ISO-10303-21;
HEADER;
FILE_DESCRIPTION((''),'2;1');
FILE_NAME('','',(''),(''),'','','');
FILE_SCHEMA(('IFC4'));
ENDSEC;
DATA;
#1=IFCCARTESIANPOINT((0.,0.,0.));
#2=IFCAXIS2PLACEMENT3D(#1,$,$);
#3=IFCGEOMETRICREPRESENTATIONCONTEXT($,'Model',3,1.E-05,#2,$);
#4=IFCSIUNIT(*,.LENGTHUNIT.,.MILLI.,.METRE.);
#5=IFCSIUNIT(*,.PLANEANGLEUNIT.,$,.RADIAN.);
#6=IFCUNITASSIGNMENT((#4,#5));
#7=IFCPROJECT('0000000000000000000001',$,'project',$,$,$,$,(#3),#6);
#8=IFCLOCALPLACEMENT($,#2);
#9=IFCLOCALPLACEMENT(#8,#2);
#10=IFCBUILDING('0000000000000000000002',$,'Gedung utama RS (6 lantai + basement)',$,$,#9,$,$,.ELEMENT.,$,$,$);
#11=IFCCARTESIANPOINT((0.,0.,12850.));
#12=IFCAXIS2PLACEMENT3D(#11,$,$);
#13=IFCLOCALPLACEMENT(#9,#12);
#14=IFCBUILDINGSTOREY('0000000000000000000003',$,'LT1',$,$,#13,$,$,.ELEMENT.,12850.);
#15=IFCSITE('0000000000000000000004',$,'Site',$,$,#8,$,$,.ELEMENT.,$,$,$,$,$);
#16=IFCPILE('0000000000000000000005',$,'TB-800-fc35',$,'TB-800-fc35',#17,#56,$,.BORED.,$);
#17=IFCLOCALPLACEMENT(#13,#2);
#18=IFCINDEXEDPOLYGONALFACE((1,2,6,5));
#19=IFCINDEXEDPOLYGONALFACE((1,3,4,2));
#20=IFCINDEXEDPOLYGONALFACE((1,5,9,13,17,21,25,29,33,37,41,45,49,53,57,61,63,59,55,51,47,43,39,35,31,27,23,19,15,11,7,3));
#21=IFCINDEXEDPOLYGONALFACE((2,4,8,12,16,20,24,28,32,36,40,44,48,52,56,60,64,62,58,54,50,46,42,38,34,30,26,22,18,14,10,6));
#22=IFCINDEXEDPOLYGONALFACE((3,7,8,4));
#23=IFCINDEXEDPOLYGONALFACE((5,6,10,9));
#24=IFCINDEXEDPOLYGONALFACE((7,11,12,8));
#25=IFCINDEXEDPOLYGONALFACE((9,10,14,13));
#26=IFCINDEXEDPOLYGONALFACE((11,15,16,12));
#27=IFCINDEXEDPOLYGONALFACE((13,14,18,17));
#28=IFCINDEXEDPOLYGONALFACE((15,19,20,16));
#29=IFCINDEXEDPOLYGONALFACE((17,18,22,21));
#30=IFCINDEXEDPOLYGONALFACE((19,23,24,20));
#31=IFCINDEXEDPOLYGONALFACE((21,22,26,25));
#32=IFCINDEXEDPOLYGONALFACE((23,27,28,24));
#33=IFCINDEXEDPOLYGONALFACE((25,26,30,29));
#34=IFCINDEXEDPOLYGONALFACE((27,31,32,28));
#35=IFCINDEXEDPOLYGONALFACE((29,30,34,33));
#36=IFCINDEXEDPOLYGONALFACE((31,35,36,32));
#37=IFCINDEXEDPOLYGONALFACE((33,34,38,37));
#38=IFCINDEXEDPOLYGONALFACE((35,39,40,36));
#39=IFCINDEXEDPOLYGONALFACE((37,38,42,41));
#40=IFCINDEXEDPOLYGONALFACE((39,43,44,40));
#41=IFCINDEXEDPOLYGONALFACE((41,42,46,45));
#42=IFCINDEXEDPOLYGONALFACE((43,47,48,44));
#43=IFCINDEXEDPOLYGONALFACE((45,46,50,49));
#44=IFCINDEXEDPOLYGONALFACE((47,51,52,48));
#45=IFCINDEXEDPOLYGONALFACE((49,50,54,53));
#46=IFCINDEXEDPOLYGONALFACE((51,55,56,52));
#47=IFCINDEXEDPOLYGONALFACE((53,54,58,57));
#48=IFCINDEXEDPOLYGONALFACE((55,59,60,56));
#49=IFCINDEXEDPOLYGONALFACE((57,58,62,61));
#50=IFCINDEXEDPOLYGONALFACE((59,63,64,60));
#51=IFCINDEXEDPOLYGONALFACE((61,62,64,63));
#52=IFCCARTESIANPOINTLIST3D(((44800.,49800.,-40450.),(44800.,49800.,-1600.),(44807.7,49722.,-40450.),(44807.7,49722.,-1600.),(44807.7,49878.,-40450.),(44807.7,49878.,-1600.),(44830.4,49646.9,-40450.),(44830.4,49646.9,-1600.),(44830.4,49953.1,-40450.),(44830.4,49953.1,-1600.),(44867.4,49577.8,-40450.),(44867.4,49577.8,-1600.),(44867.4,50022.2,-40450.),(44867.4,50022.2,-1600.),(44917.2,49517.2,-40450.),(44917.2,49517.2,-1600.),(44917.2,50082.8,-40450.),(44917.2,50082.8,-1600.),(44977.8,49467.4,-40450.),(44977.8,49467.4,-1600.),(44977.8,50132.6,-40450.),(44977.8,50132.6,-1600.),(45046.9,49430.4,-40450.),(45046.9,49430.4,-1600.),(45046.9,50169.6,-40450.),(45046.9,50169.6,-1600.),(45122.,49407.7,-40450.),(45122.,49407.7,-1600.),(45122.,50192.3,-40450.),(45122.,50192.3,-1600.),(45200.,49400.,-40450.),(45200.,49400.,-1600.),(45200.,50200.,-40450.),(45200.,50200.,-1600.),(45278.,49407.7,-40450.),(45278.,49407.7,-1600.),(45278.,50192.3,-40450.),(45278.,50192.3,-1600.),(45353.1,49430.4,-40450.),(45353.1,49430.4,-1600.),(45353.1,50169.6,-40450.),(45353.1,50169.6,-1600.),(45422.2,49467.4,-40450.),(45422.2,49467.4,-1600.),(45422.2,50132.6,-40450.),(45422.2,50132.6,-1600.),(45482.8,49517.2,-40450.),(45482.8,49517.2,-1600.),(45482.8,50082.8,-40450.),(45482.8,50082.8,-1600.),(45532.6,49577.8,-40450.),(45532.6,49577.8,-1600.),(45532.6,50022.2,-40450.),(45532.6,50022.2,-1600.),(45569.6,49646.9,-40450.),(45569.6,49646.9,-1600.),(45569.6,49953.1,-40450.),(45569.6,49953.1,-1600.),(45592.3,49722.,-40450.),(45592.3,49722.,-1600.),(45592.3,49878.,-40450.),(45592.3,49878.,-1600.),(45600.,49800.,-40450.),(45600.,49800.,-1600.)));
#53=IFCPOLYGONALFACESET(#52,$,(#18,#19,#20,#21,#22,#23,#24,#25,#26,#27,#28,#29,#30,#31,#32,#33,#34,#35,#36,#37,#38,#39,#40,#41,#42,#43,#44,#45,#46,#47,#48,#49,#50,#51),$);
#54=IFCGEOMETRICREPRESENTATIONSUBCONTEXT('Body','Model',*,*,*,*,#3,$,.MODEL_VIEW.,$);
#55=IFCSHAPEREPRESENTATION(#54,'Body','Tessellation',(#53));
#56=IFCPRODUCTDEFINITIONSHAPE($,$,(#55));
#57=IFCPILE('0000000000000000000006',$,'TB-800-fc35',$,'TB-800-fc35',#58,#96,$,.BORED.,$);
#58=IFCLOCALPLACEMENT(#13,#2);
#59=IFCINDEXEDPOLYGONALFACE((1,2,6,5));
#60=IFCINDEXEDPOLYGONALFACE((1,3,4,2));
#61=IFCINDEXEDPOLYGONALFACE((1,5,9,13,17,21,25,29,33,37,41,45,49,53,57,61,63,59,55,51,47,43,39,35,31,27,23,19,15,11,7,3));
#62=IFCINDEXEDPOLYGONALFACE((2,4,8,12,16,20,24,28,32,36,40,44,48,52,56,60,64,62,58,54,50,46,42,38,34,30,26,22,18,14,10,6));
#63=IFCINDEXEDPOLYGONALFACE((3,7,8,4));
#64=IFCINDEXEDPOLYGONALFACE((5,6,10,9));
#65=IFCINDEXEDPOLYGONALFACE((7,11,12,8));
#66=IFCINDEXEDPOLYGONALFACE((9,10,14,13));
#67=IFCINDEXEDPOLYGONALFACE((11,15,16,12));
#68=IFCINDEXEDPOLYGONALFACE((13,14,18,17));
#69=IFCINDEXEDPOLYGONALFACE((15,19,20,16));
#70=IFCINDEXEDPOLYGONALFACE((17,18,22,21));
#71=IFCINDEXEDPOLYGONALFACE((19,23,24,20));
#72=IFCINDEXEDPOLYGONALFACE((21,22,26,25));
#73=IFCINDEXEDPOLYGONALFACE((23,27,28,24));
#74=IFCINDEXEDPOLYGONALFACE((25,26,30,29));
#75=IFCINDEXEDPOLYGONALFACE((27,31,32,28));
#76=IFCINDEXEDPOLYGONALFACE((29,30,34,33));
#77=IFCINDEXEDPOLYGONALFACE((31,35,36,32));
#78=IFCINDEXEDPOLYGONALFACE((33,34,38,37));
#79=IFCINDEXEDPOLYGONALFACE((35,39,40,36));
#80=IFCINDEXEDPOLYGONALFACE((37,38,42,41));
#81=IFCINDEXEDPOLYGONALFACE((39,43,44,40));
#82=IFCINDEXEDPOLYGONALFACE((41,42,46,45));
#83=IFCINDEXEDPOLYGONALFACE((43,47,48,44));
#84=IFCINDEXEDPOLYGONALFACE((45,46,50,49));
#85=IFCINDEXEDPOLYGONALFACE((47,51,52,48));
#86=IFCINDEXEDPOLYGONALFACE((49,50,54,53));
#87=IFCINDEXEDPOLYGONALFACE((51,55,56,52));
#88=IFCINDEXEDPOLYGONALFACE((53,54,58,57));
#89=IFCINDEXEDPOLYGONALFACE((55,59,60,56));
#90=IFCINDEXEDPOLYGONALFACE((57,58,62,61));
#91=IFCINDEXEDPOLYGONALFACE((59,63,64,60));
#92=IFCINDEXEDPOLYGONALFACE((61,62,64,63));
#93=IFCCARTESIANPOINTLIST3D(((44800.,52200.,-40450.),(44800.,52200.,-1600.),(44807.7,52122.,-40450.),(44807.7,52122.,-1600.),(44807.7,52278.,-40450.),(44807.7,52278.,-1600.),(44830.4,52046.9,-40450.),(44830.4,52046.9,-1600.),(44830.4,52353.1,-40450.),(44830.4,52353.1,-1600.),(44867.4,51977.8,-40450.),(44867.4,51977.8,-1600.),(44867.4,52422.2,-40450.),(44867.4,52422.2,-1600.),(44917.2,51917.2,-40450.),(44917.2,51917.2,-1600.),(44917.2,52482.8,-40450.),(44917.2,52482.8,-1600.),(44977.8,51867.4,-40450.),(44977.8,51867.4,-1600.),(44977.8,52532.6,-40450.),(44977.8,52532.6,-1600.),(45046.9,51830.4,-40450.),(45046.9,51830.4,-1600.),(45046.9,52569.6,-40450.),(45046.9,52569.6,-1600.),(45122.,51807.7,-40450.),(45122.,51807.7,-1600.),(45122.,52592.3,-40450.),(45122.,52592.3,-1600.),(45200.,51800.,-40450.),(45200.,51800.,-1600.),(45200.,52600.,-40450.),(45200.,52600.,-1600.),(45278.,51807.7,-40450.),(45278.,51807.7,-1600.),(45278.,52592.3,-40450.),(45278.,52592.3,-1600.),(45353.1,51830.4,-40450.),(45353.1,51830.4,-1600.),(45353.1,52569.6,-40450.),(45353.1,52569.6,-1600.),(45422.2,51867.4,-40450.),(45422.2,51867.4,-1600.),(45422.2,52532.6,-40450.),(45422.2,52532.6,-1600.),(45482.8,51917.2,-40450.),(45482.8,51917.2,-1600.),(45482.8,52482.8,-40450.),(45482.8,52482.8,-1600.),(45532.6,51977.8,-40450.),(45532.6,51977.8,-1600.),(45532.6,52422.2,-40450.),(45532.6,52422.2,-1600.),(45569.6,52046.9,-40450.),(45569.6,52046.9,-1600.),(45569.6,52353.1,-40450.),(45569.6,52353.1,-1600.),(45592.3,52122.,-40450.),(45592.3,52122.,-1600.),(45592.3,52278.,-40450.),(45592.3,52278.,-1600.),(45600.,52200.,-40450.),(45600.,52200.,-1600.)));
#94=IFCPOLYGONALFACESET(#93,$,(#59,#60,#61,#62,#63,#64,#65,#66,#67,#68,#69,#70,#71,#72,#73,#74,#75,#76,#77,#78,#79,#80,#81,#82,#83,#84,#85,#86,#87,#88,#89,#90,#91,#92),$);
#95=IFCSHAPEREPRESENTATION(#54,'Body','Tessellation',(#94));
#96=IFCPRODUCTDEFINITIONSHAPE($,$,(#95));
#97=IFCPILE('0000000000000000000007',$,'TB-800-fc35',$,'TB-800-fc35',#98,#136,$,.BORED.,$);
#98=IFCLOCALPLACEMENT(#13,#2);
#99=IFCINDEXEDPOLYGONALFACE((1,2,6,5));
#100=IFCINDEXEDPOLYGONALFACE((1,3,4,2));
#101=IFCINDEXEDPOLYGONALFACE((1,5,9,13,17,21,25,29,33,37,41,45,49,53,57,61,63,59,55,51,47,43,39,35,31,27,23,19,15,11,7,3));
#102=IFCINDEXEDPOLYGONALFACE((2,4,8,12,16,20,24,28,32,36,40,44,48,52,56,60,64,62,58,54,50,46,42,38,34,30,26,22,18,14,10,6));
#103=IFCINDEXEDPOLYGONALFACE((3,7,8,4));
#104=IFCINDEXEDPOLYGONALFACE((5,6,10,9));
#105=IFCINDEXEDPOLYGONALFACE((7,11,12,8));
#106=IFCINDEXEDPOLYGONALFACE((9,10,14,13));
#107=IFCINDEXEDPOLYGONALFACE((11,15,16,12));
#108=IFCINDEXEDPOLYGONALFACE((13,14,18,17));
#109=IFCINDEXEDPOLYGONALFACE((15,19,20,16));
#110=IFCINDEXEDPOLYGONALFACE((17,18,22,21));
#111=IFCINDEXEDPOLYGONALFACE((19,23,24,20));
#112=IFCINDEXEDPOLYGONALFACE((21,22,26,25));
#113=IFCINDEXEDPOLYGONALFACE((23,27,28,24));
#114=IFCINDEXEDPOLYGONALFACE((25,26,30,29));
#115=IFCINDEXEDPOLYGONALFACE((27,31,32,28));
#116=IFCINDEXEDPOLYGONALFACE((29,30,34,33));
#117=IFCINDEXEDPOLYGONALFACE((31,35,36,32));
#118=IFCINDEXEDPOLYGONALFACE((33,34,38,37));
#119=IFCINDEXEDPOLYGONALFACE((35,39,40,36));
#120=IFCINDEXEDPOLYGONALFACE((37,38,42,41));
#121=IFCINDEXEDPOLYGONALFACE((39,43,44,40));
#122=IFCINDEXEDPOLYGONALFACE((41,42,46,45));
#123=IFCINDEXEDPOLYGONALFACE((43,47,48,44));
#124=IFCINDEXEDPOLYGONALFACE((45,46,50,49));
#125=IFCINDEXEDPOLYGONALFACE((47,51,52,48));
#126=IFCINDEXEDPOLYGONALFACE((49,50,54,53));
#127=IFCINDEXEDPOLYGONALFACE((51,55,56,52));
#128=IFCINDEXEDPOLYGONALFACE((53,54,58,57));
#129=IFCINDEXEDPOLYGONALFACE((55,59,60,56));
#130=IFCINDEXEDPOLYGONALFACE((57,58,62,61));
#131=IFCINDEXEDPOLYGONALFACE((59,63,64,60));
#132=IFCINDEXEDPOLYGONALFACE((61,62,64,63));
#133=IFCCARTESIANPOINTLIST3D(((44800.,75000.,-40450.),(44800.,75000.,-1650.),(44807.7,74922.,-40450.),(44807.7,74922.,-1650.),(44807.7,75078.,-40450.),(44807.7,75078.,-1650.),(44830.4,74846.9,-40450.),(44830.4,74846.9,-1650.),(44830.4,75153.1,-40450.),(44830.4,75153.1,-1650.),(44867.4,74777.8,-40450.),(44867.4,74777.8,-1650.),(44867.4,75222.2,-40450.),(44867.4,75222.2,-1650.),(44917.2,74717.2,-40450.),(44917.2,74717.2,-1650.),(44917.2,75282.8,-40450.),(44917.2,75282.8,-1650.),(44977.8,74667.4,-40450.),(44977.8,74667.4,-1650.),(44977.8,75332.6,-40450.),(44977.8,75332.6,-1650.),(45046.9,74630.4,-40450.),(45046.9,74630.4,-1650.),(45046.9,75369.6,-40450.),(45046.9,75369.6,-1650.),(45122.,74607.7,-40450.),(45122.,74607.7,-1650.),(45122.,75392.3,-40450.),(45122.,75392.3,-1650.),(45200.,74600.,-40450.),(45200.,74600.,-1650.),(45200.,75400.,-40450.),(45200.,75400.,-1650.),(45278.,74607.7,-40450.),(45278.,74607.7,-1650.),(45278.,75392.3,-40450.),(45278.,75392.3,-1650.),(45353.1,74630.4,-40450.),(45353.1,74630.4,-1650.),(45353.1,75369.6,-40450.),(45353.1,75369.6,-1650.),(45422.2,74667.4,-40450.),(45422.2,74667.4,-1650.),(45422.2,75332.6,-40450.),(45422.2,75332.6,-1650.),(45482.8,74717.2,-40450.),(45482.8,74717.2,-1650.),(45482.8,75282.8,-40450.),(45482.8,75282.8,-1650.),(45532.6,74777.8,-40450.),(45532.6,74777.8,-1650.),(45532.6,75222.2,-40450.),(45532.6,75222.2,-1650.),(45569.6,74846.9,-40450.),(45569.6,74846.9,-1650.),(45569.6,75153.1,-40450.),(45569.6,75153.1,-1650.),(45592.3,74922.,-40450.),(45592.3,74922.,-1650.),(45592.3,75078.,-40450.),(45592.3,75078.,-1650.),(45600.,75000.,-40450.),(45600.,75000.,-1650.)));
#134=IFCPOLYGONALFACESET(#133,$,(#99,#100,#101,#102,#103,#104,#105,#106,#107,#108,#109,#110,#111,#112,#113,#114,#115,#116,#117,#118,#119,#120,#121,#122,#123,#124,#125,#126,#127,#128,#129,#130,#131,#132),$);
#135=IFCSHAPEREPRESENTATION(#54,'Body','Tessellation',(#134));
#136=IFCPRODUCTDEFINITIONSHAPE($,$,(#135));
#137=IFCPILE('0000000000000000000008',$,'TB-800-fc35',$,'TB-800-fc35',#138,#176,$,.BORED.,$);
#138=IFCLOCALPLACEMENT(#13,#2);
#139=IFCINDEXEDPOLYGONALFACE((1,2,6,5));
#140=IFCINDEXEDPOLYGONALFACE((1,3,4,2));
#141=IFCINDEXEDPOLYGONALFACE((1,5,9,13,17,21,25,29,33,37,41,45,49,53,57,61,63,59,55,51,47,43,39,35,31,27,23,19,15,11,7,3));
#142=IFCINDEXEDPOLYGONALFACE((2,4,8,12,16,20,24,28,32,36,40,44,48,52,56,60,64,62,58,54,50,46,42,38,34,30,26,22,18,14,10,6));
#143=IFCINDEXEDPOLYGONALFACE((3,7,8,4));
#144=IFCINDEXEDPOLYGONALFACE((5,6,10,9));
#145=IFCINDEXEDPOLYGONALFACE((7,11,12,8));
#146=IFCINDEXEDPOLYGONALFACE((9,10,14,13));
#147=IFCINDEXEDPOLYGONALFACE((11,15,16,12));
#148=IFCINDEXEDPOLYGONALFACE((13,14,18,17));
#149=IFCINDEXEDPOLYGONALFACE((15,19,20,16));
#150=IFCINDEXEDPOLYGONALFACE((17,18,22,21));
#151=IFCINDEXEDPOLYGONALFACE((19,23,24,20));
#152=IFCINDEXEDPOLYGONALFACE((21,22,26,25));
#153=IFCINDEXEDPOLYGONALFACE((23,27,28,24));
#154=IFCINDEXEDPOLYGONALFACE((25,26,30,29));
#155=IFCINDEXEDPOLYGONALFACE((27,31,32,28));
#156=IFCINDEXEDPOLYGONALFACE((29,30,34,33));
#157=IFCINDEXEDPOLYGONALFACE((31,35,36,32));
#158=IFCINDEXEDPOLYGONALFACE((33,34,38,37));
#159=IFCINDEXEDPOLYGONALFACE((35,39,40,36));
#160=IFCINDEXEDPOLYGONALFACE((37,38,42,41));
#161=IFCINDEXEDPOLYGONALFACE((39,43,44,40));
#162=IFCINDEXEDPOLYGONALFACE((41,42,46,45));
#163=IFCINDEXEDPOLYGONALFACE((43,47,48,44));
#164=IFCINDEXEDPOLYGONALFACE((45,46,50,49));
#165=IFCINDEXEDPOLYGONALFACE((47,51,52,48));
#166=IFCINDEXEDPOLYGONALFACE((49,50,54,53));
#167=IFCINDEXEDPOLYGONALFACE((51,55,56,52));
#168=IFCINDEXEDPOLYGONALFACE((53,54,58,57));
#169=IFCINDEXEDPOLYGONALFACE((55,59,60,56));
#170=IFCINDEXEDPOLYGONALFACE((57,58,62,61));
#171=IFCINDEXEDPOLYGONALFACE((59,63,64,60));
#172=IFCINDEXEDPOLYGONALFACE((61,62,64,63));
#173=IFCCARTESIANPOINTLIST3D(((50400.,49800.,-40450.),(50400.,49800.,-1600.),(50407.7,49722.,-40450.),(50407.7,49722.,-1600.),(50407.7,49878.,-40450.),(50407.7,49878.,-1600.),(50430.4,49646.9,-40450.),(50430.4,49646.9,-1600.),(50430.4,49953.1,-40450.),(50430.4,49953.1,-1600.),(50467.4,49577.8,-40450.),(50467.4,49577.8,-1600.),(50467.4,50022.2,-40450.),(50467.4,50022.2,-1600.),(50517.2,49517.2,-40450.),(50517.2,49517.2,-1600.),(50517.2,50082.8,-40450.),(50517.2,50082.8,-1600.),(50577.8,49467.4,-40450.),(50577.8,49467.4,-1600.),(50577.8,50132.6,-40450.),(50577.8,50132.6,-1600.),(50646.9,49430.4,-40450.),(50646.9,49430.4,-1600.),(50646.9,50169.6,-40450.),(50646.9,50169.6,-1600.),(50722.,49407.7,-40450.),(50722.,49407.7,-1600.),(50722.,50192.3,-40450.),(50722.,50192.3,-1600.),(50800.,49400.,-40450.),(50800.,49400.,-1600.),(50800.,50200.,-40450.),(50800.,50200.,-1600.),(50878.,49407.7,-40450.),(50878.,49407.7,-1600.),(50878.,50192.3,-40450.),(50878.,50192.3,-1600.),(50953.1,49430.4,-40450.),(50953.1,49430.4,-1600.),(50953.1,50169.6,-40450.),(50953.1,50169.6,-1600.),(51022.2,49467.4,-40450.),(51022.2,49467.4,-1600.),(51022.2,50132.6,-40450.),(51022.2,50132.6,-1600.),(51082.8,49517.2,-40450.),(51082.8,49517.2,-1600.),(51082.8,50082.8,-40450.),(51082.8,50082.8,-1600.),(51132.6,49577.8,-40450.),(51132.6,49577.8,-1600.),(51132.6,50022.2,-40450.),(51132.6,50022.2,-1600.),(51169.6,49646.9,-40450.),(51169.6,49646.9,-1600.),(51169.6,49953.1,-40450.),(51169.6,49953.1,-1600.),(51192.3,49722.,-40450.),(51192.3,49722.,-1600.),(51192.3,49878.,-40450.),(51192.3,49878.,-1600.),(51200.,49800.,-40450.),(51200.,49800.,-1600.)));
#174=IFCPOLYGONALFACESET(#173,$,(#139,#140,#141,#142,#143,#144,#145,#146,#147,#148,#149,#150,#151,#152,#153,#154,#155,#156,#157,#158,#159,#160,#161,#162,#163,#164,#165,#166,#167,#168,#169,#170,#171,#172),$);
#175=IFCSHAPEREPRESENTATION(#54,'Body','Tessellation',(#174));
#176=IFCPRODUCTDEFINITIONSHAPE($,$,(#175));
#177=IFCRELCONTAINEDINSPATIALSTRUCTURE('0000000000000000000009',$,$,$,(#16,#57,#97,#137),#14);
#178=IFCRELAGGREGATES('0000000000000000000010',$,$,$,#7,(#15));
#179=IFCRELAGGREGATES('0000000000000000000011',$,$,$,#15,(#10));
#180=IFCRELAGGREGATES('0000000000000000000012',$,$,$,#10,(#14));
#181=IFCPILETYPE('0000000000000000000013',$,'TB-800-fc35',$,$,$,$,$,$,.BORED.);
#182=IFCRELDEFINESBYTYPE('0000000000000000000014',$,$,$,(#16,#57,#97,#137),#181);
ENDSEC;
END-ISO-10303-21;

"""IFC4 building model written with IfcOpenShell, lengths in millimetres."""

from ifc_helpers import new_model, si_unit, frame, origin, origin_2d, place, context, subcontext, project, spatial, circle, extrude, material_profile, profile_set, profile_usage, type_object, element, save


model = new_model("IFC4")

# Units and contexts
model_context = context("Model", 3, precision=1e-05, world=origin())
body_context = subcontext(model_context, "Body", "Model", "MODEL_VIEW")
ifc_project = project(units=[si_unit("LENGTHUNIT", "METRE", prefix="MILLI"), si_unit("PLANEANGLEUNIT", "RADIAN")], contexts=[model_context])

# Site, building, storey
site_placement = place(None, origin())
site = spatial("IfcSite", under=ifc_project, at=site_placement, Name="Site", CompositionType="ELEMENT")
building_placement = place(site_placement, origin())
building = spatial("IfcBuilding", under=site, at=building_placement, Name="Gedung utama RS (6 lantai + basement)", CompositionType="ELEMENT")
storey_placement = place(building_placement, frame((0.0, 0.0, 12850.0)))
storey = spatial("IfcBuildingStorey", under=building, at=storey_placement, Name="LT1", CompositionType="ELEMENT", Elevation=12850.0)

# Piles
ifc_material_profile_1 = material_profile(None, circle(Radius=400.0, at=origin_2d()), Name="TB-800-fc35")
ifc_profile_set_1 = profile_set([ifc_material_profile_1], Name="TB-800-fc35")
ifc_profile_usage_1 = profile_usage(ifc_profile_set_1, cardinal=5)
pile_type = type_object("IfcPileType", Name="TB-800-fc35", PredefinedType="BORED", material=ifc_profile_set_1)
for number, where, z_axis, x_axis, name in (
    (1, (45200.0, 49800.0, -40450.0), (0.0, 0.0, 1.0), (1.0, 0.0, 0.0), "TB-800-fc35"),
    (2, (45200.0, 52200.0, -40450.0), (0.0, 0.0, 1.0), (1.0, 0.0, 0.0), "TB-800-fc35"),
):
    element("IfcPile", number, at=place(storey_placement, frame(where, z_axis=z_axis, x_axis=x_axis)), inside=storey, type_object=pile_type, material=ifc_profile_usage_1, Name=name, ObjectType="TB-800-fc35", PredefinedType="BORED", context=body_context, shape_type="SweptSolid", body=[
        extrude(circle(Radius=400.0, at=origin_2d()), origin(), (0.0, 0.0, 1.0), 38850.0),
    ])
pile_placement = place(storey_placement, frame((45200.0, 75000.0, -40450.0), z_axis=(0.0, 0.0, 1.0), x_axis=(1.0, 0.0, 0.0)))
element("IfcPile", 3, at=pile_placement, inside=storey, type_object=pile_type, material=ifc_profile_usage_1, Name="TB-800-fc35", ObjectType="TB-800-fc35", PredefinedType="BORED", context=body_context, shape_type="SweptSolid", body=[
    extrude(circle(Radius=400.0, at=origin_2d()), origin(), (0.0, 0.0, 1.0), 38800.0),
])
for number, where, z_axis, x_axis, name in (
    (4, (50800.0, 49800.0, -40450.0), (0.0, 0.0, 1.0), (1.0, 0.0, 0.0), "TB-800-fc35"),
):
    element("IfcPile", number, at=place(storey_placement, frame(where, z_axis=z_axis, x_axis=x_axis)), inside=storey, type_object=pile_type, material=ifc_profile_usage_1, Name=name, ObjectType="TB-800-fc35", PredefinedType="BORED", context=body_context, shape_type="SweptSolid", body=[
        extrude(circle(Radius=400.0, at=origin_2d()), origin(), (0.0, 0.0, 1.0), 38850.0),
    ])

save(model, "model.ifc")
